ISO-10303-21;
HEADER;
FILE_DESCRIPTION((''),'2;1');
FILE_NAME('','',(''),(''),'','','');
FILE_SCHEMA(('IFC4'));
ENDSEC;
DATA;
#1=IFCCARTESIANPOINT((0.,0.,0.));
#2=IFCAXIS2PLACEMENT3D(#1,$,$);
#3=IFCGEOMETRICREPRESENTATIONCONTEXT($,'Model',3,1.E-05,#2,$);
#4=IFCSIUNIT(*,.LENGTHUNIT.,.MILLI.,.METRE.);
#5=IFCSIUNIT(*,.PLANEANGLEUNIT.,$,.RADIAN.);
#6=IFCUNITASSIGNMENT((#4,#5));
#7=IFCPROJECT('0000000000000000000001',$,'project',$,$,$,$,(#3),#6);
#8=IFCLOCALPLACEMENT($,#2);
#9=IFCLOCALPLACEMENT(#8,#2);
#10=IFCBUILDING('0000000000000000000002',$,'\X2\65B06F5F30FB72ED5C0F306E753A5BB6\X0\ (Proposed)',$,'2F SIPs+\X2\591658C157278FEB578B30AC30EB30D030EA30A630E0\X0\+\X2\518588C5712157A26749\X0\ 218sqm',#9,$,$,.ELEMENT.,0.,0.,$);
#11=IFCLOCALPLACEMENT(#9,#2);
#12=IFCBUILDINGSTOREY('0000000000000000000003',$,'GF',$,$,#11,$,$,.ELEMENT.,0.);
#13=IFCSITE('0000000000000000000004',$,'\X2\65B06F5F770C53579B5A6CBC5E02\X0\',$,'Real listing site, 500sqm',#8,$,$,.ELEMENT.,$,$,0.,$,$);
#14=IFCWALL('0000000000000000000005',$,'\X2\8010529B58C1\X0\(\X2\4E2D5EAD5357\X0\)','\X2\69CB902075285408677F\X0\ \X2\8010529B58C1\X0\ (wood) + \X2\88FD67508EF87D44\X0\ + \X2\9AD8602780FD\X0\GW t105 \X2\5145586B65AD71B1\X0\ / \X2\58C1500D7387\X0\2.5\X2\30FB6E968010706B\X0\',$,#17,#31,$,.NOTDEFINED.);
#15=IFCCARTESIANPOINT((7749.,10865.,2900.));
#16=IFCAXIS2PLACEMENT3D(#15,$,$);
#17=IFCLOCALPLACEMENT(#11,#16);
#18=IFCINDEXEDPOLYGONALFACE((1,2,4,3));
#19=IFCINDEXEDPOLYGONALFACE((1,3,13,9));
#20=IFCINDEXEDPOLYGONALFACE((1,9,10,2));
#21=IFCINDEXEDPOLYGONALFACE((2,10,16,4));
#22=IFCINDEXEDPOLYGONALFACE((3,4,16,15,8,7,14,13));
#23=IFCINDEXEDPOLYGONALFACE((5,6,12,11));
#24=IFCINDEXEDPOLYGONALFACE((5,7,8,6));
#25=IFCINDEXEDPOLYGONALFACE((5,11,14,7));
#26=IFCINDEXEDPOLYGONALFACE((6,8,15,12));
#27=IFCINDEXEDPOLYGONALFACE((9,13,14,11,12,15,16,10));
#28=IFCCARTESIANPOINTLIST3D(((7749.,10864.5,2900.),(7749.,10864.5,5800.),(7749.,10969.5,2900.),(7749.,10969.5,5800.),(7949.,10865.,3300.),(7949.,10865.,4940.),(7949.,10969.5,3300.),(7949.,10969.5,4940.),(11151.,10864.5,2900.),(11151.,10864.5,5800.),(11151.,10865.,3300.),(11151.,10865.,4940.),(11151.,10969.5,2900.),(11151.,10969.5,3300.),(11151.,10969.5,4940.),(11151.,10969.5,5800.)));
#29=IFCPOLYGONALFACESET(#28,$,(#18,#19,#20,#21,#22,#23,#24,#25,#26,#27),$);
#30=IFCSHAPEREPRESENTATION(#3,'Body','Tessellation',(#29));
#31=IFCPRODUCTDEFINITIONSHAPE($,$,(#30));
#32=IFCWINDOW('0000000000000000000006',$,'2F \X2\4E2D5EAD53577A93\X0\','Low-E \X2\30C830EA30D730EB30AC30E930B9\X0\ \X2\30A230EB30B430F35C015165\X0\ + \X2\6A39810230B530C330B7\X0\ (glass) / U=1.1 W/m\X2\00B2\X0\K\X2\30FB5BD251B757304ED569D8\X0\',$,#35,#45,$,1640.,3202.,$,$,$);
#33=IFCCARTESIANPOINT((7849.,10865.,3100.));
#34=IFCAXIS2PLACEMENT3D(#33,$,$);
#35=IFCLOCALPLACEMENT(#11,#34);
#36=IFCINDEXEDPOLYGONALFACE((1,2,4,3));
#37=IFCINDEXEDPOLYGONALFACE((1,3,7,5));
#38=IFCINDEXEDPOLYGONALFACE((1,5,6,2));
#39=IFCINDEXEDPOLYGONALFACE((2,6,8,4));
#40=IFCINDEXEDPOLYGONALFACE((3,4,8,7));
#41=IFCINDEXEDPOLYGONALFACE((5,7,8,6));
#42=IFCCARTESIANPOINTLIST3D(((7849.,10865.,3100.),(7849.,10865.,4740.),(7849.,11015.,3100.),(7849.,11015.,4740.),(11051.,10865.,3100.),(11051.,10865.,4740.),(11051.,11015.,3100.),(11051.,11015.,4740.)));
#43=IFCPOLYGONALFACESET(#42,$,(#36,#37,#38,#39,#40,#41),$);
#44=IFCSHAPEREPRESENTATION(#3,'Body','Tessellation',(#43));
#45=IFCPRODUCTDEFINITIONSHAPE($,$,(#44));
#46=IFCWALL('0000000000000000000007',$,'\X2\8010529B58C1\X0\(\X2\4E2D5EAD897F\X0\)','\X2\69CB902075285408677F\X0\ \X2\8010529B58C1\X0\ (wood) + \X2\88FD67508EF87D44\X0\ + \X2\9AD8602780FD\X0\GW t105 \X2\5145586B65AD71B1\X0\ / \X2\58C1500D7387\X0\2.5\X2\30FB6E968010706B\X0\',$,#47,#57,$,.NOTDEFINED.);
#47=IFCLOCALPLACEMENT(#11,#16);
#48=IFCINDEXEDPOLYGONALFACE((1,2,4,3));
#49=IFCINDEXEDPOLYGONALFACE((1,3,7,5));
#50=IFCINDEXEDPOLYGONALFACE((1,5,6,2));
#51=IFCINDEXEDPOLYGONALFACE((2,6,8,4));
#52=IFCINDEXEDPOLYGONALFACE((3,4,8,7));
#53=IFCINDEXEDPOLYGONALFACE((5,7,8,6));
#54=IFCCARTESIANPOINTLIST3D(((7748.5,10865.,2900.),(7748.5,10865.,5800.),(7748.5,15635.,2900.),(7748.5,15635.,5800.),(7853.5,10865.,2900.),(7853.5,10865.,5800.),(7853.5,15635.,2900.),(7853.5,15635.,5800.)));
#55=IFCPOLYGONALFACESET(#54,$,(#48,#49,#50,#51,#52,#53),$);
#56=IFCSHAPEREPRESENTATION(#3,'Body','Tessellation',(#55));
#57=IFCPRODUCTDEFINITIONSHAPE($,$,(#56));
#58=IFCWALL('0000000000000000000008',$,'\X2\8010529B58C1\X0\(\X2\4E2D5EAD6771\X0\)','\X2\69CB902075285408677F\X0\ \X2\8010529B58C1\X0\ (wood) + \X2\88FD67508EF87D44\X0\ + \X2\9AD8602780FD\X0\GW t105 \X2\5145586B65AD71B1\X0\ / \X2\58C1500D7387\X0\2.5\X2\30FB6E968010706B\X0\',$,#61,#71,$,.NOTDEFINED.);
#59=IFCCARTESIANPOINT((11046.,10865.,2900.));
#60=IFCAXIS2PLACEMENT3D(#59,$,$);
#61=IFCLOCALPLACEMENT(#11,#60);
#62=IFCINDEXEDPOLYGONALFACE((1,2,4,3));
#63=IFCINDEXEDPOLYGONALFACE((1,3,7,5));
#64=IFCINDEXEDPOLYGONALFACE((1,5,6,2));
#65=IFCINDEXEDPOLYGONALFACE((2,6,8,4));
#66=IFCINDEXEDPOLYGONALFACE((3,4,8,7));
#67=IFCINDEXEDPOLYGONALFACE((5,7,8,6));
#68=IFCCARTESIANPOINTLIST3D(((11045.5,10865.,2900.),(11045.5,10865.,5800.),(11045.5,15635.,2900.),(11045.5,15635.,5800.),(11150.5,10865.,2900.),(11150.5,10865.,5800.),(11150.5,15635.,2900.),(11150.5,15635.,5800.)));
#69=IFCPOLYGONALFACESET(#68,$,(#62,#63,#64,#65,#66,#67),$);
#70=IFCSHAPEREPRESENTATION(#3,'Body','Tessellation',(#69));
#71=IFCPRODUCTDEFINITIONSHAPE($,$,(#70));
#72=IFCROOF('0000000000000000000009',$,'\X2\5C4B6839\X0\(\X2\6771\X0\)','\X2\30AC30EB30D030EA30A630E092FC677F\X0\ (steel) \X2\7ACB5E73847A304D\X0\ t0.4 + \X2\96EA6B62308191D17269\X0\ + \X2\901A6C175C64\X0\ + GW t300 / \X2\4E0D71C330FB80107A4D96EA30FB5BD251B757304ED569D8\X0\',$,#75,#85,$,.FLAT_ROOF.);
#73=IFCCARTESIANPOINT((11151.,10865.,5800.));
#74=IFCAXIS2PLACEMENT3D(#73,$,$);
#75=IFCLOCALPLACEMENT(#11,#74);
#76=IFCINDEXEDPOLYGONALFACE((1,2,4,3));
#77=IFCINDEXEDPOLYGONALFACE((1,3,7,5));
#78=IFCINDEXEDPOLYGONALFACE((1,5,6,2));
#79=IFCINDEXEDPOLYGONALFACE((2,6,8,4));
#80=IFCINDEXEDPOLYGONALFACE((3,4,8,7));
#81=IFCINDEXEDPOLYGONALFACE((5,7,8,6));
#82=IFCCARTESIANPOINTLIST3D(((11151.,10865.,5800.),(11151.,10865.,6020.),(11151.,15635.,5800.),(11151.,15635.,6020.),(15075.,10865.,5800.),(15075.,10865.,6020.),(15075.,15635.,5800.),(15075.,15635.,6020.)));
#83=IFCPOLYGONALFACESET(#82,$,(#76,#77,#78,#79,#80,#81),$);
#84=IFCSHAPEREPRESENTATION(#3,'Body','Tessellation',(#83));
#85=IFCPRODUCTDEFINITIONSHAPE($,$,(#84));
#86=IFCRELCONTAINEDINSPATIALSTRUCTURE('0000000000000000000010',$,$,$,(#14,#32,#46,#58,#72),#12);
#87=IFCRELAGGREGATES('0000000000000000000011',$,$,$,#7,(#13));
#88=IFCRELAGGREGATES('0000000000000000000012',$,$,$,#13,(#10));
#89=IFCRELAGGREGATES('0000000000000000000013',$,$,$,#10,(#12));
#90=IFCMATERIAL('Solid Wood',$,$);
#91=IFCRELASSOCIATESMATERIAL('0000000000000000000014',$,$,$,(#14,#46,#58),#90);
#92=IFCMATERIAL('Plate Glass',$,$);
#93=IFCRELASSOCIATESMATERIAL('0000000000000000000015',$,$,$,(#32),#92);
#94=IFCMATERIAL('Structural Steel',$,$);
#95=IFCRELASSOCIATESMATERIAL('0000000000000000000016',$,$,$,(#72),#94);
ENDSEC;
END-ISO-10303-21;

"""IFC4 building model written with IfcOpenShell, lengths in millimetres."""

from ifc_helpers import new_model, si_unit, frame, frame_2d, origin, place, context, project, spatial, rectangle, extrude, material, element, fill, save


model = new_model("IFC4")

# Units and contexts
model_context = context("Model", 3, precision=1e-05, world=origin())
ifc_project = project(units=[si_unit("LENGTHUNIT", "METRE", prefix="MILLI"), si_unit("PLANEANGLEUNIT", "RADIAN")], contexts=[model_context])

# Site, building, storey
site_placement = place(None, origin())
site = spatial("IfcSite", under=ifc_project, at=site_placement, Name="新潟県南魚沼市", ObjectType="Real listing site, 500sqm", CompositionType="ELEMENT", RefElevation=0.0)
building_placement = place(site_placement, origin())
building = spatial("IfcBuilding", under=site, at=building_placement, Name="新潟・狭小の町家 (Proposed)", ObjectType="2F SIPs+外壁圧迫型ガルバリウム+内装無垢杉 218sqm", CompositionType="ELEMENT", ElevationOfRefHeight=0.0, ElevationOfTerrain=0.0)
storey_placement = place(building_placement, origin())
storey = spatial("IfcBuildingStorey", under=building, at=storey_placement, Name="GF", CompositionType="ELEMENT", Elevation=0.0)

# Shared definitions
ifc_material_1 = material(Name="Solid Wood")

# Shared definitions
ifc_material_2 = material(Name="Plate Glass")

# Wall, opening, window
wall_1_placement = place(storey_placement, frame((7749.0, 10865.0, 2900.0)))
wall_1 = element("IfcWall", 1, at=wall_1_placement, inside=storey, material=ifc_material_1, Name="耐力壁(中庭南)", Description="構造用合板 耐力壁 (wood) + 製材軸組 + 高性能GW t105 充填断熱 / 壁倍率2.5・準耐火", PredefinedType="NOTDEFINED", context=model_context, shape_type="SweptSolid", body=[
    extrude(rectangle(XDim=3402.0, YDim=105.0, at=frame_2d((1701.0, 52.0))), frame((7749.0, 10865.0, 2900.0)), (0.0, 0.0, 1.0), 2900.0),
])
opening_1_placement = place(storey_placement, frame((7849.0, 10865.0, 3100.0)))
opening_1 = element("IfcOpeningElement", 2, at=opening_1_placement, cuts=wall_1, PredefinedType="NOTDEFINED", context=model_context, shape_type="SweptSolid", body=[
    extrude(rectangle(XDim=3202.0, YDim=150.0, at=frame_2d((1601.0, 75.0))), frame((7849.0, 10865.0, 3100.0)), (0.0, 0.0, 1.0), 1640.0),
])
window_1_placement = place(storey_placement, frame((7849.0, 10865.0, 3100.0)))
window_1 = element("IfcWindow", 3, at=window_1_placement, inside=storey, material=ifc_material_2, Name="2F 中庭南窓", Description="Low-E トリプルガラス アルゴン封入 + 樹脂サッシ (glass) / U=1.1 W/m²K・寒冷地仕様", OverallHeight=1640.0, OverallWidth=3202.0, context=model_context, shape_type="SweptSolid", body=[
    extrude(rectangle(XDim=3202.0, YDim=150.0, at=frame_2d((1601.0, 75.0))), frame((7849.0, 10865.0, 3100.0)), (0.0, 0.0, 1.0), 1640.0),
])
fill(opening_1, window_1)

# Walls
wall_2_placement = place(storey_placement, frame((7749.0, 10865.0, 2900.0)))
element("IfcWall", 4, at=wall_2_placement, inside=storey, material=ifc_material_1, Name="耐力壁(中庭西)", Description="構造用合板 耐力壁 (wood) + 製材軸組 + 高性能GW t105 充填断熱 / 壁倍率2.5・準耐火", PredefinedType="NOTDEFINED", context=model_context, shape_type="SweptSolid", body=[
    extrude(rectangle(XDim=105.0, YDim=4770.0, at=frame_2d((52.0, 2385.0))), frame((7749.0, 10865.0, 2900.0)), (0.0, 0.0, 1.0), 2900.0),
])
wall_3_placement = place(storey_placement, frame((11046.0, 10865.0, 2900.0)))
element("IfcWall", 5, at=wall_3_placement, inside=storey, material=ifc_material_1, Name="耐力壁(中庭東)", Description="構造用合板 耐力壁 (wood) + 製材軸組 + 高性能GW t105 充填断熱 / 壁倍率2.5・準耐火", PredefinedType="NOTDEFINED", context=model_context, shape_type="SweptSolid", body=[
    extrude(rectangle(XDim=105.0, YDim=4770.0, at=frame_2d((52.0, 2385.0))), frame((11046.0, 10865.0, 2900.0)), (0.0, 0.0, 1.0), 2900.0),
])

# Roof
ifc_material_3 = material(Name="Structural Steel")
for number, where, name in (
    (6, (11151.0, 10865.0, 5800.0), "屋根(東)"),
):
    element("IfcRoof", number, at=place(storey_placement, frame(where)), inside=storey, material=ifc_material_3, Name=name, Description="ガルバリウム鋼板 (steel) 立平葺き t0.4 + 雪止め金物 + 通気層 + GW t300 / 不燃・耐積雪・寒冷地仕様", PredefinedType="FLAT_ROOF", context=model_context, shape_type="SweptSolid", body=[
        extrude(rectangle(XDim=3924.0, YDim=4770.0, at=frame_2d((1962.0, 2385.0))), frame((11151.0, 10865.0, 5800.0)), (0.0, 0.0, 1.0), 220.0),
    ])

save(model, "model.ifc")
